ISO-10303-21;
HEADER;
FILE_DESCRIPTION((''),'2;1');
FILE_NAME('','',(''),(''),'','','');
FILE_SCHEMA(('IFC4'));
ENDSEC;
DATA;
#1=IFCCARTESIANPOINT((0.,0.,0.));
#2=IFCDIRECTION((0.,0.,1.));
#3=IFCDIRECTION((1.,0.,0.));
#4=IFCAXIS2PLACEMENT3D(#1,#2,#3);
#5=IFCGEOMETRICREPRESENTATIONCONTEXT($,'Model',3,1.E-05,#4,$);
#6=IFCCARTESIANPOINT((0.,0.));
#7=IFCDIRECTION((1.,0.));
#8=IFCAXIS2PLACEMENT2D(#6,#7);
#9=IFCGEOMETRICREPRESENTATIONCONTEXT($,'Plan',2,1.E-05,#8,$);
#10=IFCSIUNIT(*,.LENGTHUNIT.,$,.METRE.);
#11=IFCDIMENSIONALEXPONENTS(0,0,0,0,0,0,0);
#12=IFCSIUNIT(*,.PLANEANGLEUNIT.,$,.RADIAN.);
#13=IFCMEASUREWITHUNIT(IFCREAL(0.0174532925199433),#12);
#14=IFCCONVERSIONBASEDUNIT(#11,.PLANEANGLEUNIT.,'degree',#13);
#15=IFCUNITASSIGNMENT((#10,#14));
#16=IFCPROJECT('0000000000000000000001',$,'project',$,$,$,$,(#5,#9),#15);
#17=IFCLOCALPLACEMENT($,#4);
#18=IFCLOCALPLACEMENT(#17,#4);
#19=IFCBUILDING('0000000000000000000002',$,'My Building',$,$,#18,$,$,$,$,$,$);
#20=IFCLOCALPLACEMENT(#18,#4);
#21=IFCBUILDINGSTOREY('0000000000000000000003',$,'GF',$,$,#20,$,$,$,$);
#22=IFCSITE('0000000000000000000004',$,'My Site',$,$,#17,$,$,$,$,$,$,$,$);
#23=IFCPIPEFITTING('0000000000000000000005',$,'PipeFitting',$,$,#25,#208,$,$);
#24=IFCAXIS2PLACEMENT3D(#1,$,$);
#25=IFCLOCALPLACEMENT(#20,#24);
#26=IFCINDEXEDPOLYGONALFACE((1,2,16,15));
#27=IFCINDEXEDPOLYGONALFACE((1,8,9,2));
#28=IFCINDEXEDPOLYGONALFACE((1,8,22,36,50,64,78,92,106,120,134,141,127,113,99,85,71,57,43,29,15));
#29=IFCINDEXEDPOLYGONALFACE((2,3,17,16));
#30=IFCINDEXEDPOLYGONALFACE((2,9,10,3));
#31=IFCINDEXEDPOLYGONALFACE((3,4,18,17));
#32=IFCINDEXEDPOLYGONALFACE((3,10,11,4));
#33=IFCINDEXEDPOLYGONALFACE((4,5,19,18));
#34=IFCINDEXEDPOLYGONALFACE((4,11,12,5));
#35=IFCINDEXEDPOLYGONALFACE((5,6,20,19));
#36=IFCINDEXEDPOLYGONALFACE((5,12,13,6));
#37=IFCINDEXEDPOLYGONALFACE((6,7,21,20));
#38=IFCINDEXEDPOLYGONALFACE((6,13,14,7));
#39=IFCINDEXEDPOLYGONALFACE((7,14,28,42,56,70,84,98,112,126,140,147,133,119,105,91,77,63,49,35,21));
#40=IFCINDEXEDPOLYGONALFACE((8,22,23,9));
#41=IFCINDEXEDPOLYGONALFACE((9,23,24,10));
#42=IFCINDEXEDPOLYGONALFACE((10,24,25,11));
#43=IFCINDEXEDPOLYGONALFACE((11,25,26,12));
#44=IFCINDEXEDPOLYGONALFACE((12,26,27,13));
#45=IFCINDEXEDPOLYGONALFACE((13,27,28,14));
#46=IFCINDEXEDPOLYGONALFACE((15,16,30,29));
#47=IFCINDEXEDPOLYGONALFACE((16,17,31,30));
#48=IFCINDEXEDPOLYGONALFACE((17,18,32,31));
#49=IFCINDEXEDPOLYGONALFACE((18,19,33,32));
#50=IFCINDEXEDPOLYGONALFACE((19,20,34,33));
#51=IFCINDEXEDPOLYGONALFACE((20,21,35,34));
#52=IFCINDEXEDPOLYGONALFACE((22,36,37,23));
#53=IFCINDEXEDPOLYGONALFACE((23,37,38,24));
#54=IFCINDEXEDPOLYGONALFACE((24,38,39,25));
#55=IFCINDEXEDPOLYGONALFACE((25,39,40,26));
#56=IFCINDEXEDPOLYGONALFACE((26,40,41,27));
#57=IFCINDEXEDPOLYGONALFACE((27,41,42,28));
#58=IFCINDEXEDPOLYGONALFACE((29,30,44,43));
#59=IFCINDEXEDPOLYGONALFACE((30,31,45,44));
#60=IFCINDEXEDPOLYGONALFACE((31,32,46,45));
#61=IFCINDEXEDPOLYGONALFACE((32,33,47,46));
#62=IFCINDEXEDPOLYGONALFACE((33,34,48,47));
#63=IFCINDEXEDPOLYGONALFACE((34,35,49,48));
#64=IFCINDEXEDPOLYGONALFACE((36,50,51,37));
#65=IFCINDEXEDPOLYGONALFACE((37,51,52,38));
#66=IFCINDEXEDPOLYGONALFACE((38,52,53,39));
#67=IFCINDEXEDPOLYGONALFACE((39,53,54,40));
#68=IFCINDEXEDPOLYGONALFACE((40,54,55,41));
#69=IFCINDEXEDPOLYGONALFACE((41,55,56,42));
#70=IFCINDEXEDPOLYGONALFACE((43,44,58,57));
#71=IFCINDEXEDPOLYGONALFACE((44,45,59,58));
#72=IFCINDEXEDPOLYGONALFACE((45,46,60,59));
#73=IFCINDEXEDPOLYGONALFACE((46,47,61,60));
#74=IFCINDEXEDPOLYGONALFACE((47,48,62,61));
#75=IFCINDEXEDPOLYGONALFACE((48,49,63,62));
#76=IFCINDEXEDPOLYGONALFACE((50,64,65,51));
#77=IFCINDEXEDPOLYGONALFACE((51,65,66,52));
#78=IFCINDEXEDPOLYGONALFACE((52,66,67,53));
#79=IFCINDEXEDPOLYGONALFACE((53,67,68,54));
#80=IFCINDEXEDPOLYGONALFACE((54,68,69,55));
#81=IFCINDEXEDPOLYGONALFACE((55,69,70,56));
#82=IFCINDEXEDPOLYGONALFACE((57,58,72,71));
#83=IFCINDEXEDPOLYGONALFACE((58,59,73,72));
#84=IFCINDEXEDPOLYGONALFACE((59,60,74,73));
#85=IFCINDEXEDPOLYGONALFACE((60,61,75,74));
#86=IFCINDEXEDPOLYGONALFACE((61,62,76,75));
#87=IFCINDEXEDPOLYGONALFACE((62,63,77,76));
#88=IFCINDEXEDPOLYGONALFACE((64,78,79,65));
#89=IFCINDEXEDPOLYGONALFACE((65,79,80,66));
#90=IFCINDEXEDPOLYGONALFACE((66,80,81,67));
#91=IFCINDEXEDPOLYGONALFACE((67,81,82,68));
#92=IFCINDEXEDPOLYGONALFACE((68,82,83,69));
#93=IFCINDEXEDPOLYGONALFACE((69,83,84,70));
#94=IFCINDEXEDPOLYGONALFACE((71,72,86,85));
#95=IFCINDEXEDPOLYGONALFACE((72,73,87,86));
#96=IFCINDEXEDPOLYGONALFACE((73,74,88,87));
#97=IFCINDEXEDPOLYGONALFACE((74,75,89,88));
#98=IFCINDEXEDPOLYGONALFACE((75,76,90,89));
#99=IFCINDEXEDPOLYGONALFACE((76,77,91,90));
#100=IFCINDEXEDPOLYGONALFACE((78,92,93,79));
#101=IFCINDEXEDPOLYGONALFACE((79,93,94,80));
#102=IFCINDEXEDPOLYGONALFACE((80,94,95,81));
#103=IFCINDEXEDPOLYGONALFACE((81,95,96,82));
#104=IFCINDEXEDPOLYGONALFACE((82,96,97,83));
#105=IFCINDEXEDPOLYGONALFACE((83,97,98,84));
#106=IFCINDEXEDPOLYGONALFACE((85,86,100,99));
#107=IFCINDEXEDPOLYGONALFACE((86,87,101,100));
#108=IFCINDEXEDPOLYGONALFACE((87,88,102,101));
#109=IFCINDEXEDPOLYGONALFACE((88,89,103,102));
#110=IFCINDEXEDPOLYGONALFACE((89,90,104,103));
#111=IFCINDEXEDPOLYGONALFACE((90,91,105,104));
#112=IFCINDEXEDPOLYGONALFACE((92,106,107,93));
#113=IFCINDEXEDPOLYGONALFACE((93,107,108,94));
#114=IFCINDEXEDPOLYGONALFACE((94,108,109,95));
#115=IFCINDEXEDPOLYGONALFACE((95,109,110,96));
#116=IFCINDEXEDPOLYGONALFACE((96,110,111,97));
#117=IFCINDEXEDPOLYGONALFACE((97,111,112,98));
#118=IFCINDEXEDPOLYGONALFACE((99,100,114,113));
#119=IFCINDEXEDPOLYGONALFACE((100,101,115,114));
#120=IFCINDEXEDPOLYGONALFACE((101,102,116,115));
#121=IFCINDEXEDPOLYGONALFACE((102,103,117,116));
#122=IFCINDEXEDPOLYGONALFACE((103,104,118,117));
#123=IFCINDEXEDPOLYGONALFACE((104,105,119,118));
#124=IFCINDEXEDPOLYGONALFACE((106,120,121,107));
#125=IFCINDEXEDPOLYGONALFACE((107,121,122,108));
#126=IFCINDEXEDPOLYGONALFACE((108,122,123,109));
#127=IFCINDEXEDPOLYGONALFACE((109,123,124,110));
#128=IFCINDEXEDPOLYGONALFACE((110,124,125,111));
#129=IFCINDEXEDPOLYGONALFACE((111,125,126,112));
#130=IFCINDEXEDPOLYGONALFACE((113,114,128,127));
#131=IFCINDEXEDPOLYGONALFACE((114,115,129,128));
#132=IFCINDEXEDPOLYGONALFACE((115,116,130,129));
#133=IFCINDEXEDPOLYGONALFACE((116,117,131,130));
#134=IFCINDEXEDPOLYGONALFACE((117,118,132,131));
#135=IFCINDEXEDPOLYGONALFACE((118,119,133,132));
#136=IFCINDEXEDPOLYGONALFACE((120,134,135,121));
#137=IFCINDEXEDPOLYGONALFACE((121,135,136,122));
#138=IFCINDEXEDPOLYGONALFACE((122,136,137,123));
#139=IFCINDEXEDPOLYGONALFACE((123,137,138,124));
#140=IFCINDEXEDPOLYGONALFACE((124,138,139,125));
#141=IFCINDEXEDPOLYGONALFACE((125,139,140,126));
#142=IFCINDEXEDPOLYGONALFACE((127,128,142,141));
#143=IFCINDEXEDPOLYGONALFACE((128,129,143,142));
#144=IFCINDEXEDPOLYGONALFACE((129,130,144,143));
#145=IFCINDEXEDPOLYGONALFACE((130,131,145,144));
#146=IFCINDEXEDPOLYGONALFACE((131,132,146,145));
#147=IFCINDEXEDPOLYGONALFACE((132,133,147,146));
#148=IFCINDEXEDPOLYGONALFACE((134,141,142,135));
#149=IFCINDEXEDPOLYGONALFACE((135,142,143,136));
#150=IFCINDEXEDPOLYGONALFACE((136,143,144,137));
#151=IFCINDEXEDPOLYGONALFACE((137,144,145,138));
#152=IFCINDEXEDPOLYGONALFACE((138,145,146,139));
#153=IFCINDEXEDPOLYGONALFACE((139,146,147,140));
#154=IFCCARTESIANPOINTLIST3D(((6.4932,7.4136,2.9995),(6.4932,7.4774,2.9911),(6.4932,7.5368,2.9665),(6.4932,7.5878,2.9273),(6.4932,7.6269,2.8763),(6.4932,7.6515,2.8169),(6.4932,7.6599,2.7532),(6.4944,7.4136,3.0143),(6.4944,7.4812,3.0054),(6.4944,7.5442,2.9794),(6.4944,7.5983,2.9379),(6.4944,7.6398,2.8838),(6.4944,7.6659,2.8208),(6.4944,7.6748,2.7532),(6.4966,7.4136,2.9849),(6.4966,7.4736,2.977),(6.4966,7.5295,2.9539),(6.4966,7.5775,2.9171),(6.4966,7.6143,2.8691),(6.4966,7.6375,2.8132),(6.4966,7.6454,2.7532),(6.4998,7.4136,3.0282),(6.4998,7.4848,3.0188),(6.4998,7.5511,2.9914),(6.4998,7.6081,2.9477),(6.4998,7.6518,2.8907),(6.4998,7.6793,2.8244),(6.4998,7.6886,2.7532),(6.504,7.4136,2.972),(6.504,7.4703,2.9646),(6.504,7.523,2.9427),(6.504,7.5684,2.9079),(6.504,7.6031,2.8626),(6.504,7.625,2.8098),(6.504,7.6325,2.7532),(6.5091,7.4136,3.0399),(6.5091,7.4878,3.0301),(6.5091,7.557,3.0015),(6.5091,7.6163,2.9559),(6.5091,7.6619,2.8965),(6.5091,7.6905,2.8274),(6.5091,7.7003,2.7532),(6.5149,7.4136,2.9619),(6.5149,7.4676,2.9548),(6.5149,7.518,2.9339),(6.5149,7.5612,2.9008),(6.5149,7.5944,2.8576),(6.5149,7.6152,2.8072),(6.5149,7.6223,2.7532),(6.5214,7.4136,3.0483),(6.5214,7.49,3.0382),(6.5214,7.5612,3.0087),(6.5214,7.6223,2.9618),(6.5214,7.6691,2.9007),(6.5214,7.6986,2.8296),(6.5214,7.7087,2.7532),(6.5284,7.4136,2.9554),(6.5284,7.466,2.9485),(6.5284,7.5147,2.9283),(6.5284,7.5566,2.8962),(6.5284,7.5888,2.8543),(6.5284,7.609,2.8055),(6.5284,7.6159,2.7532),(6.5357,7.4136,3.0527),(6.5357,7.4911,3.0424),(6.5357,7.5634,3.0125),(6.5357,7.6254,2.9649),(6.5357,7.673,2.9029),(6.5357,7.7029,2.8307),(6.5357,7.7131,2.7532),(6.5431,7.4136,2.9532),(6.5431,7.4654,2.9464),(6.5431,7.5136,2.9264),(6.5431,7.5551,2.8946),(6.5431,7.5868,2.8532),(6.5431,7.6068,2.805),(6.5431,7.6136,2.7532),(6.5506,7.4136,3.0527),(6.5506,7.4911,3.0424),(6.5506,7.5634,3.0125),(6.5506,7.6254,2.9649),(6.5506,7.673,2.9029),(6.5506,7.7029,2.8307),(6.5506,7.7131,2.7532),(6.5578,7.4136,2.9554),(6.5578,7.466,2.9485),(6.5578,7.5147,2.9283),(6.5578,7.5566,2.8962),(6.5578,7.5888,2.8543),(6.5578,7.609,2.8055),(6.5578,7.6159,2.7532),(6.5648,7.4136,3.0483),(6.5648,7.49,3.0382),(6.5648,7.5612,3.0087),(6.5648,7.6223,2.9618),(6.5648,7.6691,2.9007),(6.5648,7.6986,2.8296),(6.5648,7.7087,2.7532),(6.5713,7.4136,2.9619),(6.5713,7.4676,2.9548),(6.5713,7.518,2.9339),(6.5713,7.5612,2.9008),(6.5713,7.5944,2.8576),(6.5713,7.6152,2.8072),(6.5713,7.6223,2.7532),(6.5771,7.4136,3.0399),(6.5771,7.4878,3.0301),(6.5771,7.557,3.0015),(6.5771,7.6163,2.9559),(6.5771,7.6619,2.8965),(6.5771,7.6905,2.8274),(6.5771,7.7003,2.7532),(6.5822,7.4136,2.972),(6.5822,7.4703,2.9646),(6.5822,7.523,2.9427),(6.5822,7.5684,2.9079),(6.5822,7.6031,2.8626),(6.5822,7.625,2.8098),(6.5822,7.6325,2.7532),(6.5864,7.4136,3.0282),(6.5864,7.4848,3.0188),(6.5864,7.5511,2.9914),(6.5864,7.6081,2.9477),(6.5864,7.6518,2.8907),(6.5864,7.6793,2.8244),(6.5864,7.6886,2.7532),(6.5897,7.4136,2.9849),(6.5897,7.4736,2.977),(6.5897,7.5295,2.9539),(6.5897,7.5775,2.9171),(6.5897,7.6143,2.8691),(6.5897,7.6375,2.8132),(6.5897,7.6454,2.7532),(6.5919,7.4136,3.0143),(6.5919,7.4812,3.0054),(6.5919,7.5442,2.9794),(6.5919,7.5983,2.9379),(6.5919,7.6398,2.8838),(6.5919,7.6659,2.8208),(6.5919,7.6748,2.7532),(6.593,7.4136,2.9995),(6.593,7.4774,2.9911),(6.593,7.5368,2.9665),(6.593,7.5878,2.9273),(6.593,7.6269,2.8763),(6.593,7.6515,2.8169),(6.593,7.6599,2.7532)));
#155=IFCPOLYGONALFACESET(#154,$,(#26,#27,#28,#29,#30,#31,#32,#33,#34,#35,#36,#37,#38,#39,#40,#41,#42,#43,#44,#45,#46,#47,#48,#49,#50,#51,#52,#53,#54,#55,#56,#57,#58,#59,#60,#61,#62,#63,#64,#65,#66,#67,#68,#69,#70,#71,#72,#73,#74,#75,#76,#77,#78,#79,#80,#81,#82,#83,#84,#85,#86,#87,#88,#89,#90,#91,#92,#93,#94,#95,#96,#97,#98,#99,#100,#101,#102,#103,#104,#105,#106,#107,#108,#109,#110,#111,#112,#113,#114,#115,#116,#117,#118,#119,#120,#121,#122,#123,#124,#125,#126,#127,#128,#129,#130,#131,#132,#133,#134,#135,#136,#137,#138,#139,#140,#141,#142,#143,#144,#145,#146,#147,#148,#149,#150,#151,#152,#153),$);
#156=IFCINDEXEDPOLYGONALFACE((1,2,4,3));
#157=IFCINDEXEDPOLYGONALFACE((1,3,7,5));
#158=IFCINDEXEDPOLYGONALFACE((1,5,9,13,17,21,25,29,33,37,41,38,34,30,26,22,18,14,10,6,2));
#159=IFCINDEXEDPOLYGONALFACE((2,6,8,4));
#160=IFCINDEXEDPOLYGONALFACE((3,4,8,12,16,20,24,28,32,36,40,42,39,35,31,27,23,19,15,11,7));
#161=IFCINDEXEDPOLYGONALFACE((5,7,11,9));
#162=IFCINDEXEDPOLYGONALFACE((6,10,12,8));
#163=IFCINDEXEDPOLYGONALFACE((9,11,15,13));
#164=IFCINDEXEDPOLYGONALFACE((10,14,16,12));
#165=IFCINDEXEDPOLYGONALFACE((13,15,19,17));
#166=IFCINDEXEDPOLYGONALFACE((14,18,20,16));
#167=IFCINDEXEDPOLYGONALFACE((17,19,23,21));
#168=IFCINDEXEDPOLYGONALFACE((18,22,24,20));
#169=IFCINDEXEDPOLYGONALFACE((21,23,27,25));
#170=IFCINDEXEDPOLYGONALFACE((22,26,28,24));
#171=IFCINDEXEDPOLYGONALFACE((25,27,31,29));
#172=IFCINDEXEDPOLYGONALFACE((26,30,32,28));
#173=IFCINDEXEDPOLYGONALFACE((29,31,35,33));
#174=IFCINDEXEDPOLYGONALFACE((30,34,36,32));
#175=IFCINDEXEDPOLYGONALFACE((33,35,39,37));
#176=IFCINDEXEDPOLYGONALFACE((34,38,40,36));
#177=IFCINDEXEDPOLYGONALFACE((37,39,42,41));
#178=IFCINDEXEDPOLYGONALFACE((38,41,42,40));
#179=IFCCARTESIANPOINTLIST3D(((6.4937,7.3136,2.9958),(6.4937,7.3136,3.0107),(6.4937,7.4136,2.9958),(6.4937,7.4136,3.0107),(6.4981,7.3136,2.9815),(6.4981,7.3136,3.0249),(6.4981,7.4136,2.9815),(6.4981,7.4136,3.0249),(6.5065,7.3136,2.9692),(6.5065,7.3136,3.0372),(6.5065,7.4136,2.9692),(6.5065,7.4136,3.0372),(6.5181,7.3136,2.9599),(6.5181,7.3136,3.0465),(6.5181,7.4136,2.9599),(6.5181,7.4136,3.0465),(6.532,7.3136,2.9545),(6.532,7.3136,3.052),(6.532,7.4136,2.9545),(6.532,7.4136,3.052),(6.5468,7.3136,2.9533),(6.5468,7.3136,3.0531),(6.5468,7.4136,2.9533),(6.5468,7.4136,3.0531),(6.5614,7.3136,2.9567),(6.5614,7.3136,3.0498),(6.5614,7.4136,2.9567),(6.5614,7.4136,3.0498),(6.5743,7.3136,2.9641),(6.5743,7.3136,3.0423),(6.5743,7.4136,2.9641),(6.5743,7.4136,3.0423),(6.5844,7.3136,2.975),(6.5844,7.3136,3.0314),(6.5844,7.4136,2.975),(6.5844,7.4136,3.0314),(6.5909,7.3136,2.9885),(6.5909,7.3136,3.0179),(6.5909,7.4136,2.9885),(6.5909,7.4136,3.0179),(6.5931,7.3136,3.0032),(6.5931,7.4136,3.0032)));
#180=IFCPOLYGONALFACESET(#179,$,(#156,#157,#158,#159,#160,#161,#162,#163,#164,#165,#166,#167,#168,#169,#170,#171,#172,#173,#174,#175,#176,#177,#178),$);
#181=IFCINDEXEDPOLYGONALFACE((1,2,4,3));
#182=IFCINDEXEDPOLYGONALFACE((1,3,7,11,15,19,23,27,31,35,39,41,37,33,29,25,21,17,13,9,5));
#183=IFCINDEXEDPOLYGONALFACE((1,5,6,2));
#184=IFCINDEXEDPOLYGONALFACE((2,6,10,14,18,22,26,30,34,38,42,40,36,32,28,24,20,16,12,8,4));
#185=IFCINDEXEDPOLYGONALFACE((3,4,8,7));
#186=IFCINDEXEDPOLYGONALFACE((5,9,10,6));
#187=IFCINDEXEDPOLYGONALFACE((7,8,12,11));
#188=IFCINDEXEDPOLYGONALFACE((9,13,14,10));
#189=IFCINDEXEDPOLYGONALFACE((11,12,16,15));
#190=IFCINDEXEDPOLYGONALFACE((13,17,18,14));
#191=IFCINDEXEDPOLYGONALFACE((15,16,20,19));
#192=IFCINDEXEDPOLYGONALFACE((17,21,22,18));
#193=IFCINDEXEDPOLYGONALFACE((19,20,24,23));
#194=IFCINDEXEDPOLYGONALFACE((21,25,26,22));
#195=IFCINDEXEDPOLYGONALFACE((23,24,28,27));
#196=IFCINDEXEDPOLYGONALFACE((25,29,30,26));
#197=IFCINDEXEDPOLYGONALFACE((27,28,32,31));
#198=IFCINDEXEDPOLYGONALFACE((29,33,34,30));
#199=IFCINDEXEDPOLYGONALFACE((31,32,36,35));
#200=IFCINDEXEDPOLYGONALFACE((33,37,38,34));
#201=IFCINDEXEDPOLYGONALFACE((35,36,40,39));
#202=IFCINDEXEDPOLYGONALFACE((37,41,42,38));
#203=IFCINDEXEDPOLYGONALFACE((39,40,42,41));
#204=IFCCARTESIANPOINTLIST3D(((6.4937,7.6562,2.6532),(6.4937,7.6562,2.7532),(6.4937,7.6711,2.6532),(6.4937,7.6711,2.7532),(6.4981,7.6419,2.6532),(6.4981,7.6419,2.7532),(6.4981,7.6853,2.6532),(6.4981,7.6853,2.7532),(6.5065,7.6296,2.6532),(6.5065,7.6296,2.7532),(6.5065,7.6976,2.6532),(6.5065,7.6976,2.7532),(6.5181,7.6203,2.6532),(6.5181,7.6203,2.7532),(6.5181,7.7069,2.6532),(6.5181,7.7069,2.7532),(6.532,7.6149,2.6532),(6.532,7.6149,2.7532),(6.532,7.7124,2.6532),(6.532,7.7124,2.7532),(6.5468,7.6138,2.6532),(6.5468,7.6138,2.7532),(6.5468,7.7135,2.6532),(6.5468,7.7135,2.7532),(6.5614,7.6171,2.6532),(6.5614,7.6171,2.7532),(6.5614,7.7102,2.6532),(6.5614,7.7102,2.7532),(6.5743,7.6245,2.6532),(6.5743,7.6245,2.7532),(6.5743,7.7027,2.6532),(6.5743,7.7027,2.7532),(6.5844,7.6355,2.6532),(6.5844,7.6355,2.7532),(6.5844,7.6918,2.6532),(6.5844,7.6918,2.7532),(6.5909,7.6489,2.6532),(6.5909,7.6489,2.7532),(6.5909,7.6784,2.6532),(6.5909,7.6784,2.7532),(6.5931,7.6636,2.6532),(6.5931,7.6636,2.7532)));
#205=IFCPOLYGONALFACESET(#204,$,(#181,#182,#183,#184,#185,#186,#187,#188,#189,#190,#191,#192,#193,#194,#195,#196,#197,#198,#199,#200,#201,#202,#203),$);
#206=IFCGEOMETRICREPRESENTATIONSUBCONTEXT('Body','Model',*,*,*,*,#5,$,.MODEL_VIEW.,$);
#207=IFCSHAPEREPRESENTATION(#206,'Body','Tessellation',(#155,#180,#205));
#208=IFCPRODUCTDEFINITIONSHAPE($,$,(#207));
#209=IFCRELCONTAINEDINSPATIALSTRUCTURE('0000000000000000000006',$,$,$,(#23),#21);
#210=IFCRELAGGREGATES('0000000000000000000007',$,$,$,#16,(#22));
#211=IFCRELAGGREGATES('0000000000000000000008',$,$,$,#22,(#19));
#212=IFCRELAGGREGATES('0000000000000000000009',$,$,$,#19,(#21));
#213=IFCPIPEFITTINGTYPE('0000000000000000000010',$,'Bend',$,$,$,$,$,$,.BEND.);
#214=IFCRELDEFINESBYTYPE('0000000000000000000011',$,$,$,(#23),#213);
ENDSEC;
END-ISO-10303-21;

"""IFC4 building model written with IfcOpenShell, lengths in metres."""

from ifc_helpers import new_model, entity, si_unit, converted_unit, frame, origin_with_axes, origin_2d_with_axis, place, context, subcontext, project, spatial, circle, extrude, source, transform, mapped, type_object, type_shapes, element, save


model = new_model("IFC4")

# Units and contexts
model_context = context("Model", 3, precision=1e-05, world=origin_with_axes())
plan_context = context("Plan", 2, precision=1e-05, world=origin_2d_with_axis())
body_context_1 = subcontext(model_context, "Body", "Model", "MODEL_VIEW")
ifc_project = project(units=[si_unit("LENGTHUNIT", "METRE"), converted_unit("PLANEANGLEUNIT", "degree", entity("IfcReal", 0.0174532925199433), si_unit("PLANEANGLEUNIT", "RADIAN"), dimensions=[0, 0, 0, 0, 0, 0, 0])], contexts=[model_context, plan_context])

# Site, building, storey
site_placement = place(None, origin_with_axes())
site = spatial("IfcSite", under=ifc_project, at=site_placement, Name="My Site")
building_placement = place(site_placement, origin_with_axes())
building = spatial("IfcBuilding", under=site, at=building_placement, Name="My Building")
storey_placement = place(building_placement, origin_with_axes())
storey = spatial("IfcBuildingStorey", under=building, at=storey_placement, Name="GF")

# Shared definitions
pipe_fitting_type = type_object("IfcPipeFittingType", Name="Bend", PredefinedType="BEND")
shared_shape_1 = source(origin_with_axes(), body_context_1, "Body", "SolidModel", [
    entity("IfcSweptDiskSolid", entity("IfcIndexedPolyCurve", entity("IfcCartesianPointList3D", [[0.0, 0.0, -0.1], [0.0, -0.0732, -0.2768], [0.0, -0.25, -0.35]]), [entity("IfcArcIndex", [1, 2, 3])]), 0.05),
    extrude(circle(Radius=0.05), origin_with_axes(), (0.0, 0.0, -1.0), 0.1),
    extrude(circle(Radius=0.05), frame((0.0, -0.25, -0.35), z_axis=(0.0, -1.0, 0.0), x_axis=(1.0, 0.0, 0.0)), (0.0, 0.0, 1.0), 0.1),
])
type_shapes(pipe_fitting_type, [shared_shape_1])

# Pipe fitting
for number, where, z_axis, x_axis, name in (
    (1, (6.5431, 7.3136, 3.0032), (0.0, -1.0, 0.0), (1.0, 0.0, 0.0), "PipeFitting"),
):
    element("IfcPipeFitting", number, at=place(storey_placement, frame(where, z_axis=z_axis, x_axis=x_axis)), inside=storey, type_object=pipe_fitting_type, Name=name, context=body_context_1, shape_type="MappedRepresentation", body=[
        mapped(shared_shape_1, transform((0.0, 0.0, 0.0), x_axis=(1.0, 0.0, 0.0), y_axis=(0.0, 1.0, 0.0), z_axis=(0.0, 0.0, 1.0), scale=1.0)),
    ])

save(model, "model.ifc")
